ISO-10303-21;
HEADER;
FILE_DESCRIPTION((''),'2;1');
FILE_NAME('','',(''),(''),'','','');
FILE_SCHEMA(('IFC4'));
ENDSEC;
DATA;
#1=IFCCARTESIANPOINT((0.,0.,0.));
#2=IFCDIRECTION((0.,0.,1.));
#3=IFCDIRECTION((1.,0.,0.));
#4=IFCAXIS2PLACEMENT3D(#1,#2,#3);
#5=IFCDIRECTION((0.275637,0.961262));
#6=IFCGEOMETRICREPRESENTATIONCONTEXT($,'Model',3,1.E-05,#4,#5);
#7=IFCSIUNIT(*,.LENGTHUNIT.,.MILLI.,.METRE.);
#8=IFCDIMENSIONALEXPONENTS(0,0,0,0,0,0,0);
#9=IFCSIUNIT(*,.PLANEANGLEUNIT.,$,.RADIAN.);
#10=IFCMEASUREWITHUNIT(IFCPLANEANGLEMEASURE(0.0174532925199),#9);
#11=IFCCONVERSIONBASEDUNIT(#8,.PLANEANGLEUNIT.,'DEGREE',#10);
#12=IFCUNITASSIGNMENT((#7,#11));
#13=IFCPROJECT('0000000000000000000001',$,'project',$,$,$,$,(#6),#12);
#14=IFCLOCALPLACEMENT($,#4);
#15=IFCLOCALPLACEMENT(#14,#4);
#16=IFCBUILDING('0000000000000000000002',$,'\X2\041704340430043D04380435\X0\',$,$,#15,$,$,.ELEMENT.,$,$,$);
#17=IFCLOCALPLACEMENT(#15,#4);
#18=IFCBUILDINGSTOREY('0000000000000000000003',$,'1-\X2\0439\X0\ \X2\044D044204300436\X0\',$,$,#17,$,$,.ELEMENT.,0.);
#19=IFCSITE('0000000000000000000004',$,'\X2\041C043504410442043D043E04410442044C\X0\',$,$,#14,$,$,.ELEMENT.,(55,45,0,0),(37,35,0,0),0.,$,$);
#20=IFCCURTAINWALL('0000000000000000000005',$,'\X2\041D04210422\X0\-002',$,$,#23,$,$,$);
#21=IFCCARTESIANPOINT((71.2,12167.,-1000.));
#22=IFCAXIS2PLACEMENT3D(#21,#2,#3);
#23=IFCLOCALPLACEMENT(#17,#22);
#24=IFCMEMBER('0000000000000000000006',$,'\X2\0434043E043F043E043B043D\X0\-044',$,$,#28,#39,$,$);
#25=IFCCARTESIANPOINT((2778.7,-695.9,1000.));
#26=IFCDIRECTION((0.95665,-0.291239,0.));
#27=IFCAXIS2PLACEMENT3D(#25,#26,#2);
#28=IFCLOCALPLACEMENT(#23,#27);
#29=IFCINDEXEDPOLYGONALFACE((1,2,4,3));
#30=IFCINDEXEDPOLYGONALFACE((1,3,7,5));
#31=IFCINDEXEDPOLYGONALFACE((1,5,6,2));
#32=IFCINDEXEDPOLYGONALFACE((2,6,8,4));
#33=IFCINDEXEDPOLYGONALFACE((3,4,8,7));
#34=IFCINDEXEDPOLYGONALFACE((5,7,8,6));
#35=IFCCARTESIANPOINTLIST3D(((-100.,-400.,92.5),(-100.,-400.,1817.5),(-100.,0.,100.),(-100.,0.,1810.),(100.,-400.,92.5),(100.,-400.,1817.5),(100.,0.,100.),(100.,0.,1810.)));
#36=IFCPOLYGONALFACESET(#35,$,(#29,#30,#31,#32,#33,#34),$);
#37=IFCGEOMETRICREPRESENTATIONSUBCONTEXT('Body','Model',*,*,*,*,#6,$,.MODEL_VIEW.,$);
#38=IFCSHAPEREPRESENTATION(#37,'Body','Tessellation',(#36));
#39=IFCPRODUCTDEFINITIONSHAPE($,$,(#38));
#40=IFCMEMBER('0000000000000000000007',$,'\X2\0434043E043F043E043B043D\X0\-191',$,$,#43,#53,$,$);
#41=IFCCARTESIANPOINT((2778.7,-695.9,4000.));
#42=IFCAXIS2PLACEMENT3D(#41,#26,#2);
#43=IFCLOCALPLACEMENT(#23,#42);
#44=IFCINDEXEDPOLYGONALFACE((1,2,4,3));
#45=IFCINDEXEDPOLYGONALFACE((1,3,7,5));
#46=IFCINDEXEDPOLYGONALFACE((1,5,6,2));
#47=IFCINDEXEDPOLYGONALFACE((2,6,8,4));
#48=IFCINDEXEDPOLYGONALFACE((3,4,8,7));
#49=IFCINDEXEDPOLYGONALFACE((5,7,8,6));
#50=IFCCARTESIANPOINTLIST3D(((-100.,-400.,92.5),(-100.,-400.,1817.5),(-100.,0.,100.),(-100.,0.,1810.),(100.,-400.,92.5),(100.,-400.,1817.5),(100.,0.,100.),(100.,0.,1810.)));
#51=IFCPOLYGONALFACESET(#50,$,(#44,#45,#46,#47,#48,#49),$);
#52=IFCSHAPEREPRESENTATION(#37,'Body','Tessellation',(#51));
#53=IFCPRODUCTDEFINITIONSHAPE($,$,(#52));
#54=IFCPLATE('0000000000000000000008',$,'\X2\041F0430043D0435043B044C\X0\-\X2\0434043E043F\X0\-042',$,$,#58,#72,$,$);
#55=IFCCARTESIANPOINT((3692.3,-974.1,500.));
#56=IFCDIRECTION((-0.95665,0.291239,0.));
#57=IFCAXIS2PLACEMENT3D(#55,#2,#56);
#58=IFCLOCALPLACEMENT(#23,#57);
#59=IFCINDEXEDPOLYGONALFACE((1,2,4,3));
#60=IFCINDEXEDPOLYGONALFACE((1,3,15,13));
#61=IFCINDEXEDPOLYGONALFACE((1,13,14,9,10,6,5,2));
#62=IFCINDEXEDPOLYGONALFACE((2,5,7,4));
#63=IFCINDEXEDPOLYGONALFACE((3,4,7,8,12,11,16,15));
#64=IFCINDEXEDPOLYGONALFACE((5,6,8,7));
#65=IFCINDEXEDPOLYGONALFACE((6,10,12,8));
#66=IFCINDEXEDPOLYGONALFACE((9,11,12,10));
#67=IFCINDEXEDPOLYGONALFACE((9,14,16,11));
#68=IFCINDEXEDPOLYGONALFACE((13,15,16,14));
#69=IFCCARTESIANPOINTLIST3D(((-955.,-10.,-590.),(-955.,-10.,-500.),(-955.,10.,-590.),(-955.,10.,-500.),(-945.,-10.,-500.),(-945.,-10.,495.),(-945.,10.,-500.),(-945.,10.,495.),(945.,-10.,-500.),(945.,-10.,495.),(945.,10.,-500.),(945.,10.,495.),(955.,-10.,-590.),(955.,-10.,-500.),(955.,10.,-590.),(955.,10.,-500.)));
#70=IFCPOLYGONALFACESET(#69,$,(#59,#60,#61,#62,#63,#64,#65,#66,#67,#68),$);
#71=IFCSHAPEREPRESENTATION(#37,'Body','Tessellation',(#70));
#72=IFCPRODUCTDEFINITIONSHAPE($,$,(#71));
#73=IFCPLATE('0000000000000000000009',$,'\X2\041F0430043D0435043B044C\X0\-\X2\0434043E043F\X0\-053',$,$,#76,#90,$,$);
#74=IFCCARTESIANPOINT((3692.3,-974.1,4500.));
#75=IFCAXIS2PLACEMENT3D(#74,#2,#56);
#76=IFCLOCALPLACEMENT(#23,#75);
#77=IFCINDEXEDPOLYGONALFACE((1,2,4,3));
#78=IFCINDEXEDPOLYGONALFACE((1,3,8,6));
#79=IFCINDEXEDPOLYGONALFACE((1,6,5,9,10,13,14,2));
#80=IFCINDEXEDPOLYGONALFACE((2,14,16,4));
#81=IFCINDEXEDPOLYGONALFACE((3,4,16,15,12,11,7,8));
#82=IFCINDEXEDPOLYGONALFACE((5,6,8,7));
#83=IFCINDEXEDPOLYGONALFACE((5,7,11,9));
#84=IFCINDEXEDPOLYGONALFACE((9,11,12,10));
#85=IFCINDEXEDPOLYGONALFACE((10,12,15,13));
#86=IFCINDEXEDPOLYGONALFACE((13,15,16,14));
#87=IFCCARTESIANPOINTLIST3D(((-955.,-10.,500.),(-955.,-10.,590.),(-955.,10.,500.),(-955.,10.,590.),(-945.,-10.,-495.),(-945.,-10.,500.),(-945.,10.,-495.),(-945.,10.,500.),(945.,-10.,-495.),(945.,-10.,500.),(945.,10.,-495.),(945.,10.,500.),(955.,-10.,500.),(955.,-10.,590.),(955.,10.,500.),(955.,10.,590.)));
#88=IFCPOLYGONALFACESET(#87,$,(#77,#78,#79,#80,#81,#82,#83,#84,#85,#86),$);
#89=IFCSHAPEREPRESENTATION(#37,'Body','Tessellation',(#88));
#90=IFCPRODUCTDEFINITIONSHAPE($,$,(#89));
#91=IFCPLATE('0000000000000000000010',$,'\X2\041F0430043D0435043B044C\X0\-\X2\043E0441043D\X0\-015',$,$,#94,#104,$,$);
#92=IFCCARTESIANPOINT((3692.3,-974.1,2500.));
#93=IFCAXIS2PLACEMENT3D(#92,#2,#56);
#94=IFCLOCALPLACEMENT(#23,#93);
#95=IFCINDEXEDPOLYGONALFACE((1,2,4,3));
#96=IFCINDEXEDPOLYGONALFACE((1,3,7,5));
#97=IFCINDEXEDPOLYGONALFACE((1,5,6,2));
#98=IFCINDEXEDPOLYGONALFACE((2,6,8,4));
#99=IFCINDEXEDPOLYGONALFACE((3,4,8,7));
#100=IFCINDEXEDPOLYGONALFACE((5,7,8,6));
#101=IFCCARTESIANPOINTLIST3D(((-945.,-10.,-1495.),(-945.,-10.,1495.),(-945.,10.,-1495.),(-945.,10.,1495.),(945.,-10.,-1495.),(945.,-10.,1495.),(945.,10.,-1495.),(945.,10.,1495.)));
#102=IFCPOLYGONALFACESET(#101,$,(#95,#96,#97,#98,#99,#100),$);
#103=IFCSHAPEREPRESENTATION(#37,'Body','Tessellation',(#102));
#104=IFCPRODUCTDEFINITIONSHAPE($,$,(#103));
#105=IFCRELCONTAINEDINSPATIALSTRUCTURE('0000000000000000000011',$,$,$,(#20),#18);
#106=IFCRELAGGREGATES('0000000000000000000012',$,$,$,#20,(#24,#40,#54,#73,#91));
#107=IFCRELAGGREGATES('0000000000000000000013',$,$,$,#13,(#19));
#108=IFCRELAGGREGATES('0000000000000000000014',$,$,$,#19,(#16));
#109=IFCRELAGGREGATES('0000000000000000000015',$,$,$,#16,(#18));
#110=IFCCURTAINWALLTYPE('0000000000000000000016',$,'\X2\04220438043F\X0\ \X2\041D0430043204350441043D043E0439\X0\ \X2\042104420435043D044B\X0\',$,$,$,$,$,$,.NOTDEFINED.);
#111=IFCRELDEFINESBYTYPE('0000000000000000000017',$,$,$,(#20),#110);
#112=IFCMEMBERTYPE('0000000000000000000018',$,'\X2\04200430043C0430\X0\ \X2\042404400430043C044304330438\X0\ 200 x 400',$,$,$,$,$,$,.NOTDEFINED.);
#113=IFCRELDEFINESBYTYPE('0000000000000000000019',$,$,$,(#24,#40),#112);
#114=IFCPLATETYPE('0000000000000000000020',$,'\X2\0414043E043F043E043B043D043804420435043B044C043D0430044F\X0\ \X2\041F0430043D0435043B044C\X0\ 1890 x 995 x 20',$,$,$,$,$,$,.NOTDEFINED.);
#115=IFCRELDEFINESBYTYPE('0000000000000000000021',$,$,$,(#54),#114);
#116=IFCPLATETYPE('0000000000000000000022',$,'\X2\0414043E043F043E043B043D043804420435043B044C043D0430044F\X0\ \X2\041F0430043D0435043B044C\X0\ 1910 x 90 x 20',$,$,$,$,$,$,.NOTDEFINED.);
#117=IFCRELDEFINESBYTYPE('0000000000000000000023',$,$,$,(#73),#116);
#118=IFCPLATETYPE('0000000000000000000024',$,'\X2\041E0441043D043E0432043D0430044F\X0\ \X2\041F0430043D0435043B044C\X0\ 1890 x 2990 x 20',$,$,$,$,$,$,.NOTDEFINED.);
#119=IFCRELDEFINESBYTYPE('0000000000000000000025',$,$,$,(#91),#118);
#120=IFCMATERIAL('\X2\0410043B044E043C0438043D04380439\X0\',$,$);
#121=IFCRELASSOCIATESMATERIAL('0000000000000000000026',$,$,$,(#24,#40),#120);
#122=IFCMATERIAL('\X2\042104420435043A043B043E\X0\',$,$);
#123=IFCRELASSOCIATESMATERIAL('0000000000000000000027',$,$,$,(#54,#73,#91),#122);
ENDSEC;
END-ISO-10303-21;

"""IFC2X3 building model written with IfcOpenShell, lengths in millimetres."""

from ifc_helpers import new_model, entity, si_unit, converted_unit, direction, frame, origin_with_axes, place, context, subcontext, project, spatial, polyline, outline, extrude, clip, halfspace, material, type_object, element, aggregate, save


model = new_model("IFC2X3")

# Units and contexts
model_context = context("Model", 3, precision=1e-05, world=origin_with_axes(), true_north=direction((0.275637, 0.961262)))
body_context = subcontext(model_context, "Body", "Model", "MODEL_VIEW")
ifc_project = project(units=[si_unit("LENGTHUNIT", "METRE", prefix="MILLI"), converted_unit("PLANEANGLEUNIT", "DEGREE", entity("IfcPlaneAngleMeasure", 0.0174532925199), si_unit("PLANEANGLEUNIT", "RADIAN"), dimensions=[0, 0, 0, 0, 0, 0, 0])], contexts=[model_context])

# Site, building, storey
site_placement = place(None, origin_with_axes())
site = spatial("IfcSite", under=ifc_project, at=site_placement, Name="Местность", CompositionType="ELEMENT", RefLatitude=(55, 45, 0, 0), RefLongitude=(37, 35, 0, 0), RefElevation=0.0)
building_placement = place(site_placement, origin_with_axes())
building = spatial("IfcBuilding", under=site, at=building_placement, Name="Здание", CompositionType="ELEMENT")
storey_placement = place(building_placement, origin_with_axes())
storey = spatial("IfcBuildingStorey", under=building, at=storey_placement, Name="1-й этаж", CompositionType="ELEMENT", Elevation=0.0)

# Curtain wall, members, plates
curtain_wall_type = type_object("IfcCurtainWallType", Name="Тип Навесной Стены", PredefinedType="NOTDEFINED")
curtain_wall_placement = place(storey_placement, frame((71.2, 12167.0, -1000.0), z_axis=(0.0, 0.0, 1.0), x_axis=(1.0, 0.0, 0.0)))
curtain_wall = element("IfcCurtainWall", 1, at=curtain_wall_placement, inside=storey, type_object=curtain_wall_type, Name="НСТ-002")
ifc_material_1 = material(Name="Алюминий")
member_type_1 = type_object("IfcMemberType", Name="Рама Фрамуги 200 x 400", PredefinedType="NOTDEFINED")
member_1_placement = place(curtain_wall_placement, frame((2778.7, -695.9, 1000.0), z_axis=(0.95665, -0.291239, 0.0), x_axis=(0.0, 0.0, 1.0)))
member_1 = element("IfcMember", 2, at=member_1_placement, type_object=member_type_1, material=ifc_material_1, Name="дополн-044", context=body_context, shape_type="Clipping", body=[
    clip(clip(extrude(outline(polyline([(-400.0, -100.0), (0.0, -100.0), (0.0, 100.0), (-400.0, 100.0), (-400.0, -100.0)])), frame((0.0, 0.0, 92.5), z_axis=(0.0, 0.0, 1.0), x_axis=(0.0, 1.0, 0.0)), (0.0, 0.0, 1.0), 1725.0), halfspace(frame((0.0, 34.0, 1809.3), z_axis=(0.0, -0.018792, -0.999823), x_axis=(0.0, 0.999823, -0.018792)), True)), halfspace(frame((0.0, -1.9, 100.0), z_axis=(0.0, -0.018792, 0.999823), x_axis=(0.0, -0.999823, -0.018792)), True)),
])
member_2_placement = place(curtain_wall_placement, frame((2778.7, -695.9, 4000.0), z_axis=(0.95665, -0.291239, 0.0), x_axis=(0.0, 0.0, 1.0)))
member_2 = element("IfcMember", 3, at=member_2_placement, type_object=member_type_1, material=ifc_material_1, Name="дополн-191", context=body_context, shape_type="Clipping", body=[
    clip(clip(extrude(outline(polyline([(-400.0, -100.0), (0.0, -100.0), (0.0, 100.0), (-400.0, 100.0), (-400.0, -100.0)])), frame((0.0, 0.0, 92.5), z_axis=(0.0, 0.0, 1.0), x_axis=(0.0, 1.0, 0.0)), (0.0, 0.0, 1.0), 1725.0), halfspace(frame((0.0, 34.0, 1809.3), z_axis=(0.0, -0.018792, -0.999823), x_axis=(0.0, 0.999823, -0.018792)), True)), halfspace(frame((0.0, -1.9, 100.0), z_axis=(0.0, -0.018792, 0.999823), x_axis=(0.0, -0.999823, -0.018792)), True)),
])
ifc_material_2 = material(Name="Стекло")
plate_type_1 = type_object("IfcPlateType", Name="Дополнительная Панель 1890 x 995 x 20", PredefinedType="NOTDEFINED")
plate_1_placement = place(curtain_wall_placement, frame((3692.3, -974.1, 500.0), z_axis=(0.0, 0.0, 1.0), x_axis=(-0.95665, 0.291239, 0.0)))
plate_1 = element("IfcPlate", 4, at=plate_1_placement, type_object=plate_type_1, material=ifc_material_2, Name="Панель-доп-042", context=body_context, shape_type="SweptSolid", body=[
    extrude(outline(polyline([(-945.0, -495.0), (945.0, -495.0), (945.0, 500.0), (955.0, 500.0), (955.0, 590.0), (-955.0, 590.0), (-955.0, 500.0), (-945.0, 500.0), (-945.0, -495.0)])), frame((0.0, -10.0, 0.0), z_axis=(0.0, 1.0, 0.0), x_axis=(1.0, 0.0, 0.0)), (0.0, 0.0, 1.0), 20.0),
])
plate_type_2 = type_object("IfcPlateType", Name="Дополнительная Панель 1910 x 90 x 20", PredefinedType="NOTDEFINED")
plate_2_placement = place(curtain_wall_placement, frame((3692.3, -974.1, 4500.0), z_axis=(0.0, 0.0, 1.0), x_axis=(-0.95665, 0.291239, 0.0)))
plate_2 = element("IfcPlate", 5, at=plate_2_placement, type_object=plate_type_2, material=ifc_material_2, Name="Панель-доп-053", context=body_context, shape_type="SweptSolid", body=[
    extrude(outline(polyline([(-955.0, -590.0), (955.0, -590.0), (955.0, -500.0), (945.0, -500.0), (945.0, 495.0), (-945.0, 495.0), (-945.0, -500.0), (-955.0, -500.0), (-955.0, -590.0)])), frame((0.0, -10.0, 0.0), z_axis=(0.0, 1.0, 0.0), x_axis=(1.0, 0.0, 0.0)), (0.0, 0.0, 1.0), 20.0),
])
plate_type_3 = type_object("IfcPlateType", Name="Основная Панель 1890 x 2990 x 20", PredefinedType="NOTDEFINED")
plate_3_placement = place(curtain_wall_placement, frame((3692.3, -974.1, 2500.0), z_axis=(0.0, 0.0, 1.0), x_axis=(-0.95665, 0.291239, 0.0)))
plate_3 = element("IfcPlate", 6, at=plate_3_placement, type_object=plate_type_3, material=ifc_material_2, Name="Панель-осн-015", context=body_context, shape_type="SweptSolid", body=[
    extrude(outline(polyline([(-945.0, -1495.0), (945.0, -1495.0), (945.0, 1495.0), (-945.0, 1495.0), (-945.0, -1495.0)])), frame((0.0, -10.0, 0.0), z_axis=(0.0, 1.0, 0.0), x_axis=(1.0, 0.0, 0.0)), (0.0, 0.0, 1.0), 20.0),
])
aggregate(curtain_wall, [member_1, member_2, plate_1, plate_2, plate_3])

save(model, "model.ifc")
